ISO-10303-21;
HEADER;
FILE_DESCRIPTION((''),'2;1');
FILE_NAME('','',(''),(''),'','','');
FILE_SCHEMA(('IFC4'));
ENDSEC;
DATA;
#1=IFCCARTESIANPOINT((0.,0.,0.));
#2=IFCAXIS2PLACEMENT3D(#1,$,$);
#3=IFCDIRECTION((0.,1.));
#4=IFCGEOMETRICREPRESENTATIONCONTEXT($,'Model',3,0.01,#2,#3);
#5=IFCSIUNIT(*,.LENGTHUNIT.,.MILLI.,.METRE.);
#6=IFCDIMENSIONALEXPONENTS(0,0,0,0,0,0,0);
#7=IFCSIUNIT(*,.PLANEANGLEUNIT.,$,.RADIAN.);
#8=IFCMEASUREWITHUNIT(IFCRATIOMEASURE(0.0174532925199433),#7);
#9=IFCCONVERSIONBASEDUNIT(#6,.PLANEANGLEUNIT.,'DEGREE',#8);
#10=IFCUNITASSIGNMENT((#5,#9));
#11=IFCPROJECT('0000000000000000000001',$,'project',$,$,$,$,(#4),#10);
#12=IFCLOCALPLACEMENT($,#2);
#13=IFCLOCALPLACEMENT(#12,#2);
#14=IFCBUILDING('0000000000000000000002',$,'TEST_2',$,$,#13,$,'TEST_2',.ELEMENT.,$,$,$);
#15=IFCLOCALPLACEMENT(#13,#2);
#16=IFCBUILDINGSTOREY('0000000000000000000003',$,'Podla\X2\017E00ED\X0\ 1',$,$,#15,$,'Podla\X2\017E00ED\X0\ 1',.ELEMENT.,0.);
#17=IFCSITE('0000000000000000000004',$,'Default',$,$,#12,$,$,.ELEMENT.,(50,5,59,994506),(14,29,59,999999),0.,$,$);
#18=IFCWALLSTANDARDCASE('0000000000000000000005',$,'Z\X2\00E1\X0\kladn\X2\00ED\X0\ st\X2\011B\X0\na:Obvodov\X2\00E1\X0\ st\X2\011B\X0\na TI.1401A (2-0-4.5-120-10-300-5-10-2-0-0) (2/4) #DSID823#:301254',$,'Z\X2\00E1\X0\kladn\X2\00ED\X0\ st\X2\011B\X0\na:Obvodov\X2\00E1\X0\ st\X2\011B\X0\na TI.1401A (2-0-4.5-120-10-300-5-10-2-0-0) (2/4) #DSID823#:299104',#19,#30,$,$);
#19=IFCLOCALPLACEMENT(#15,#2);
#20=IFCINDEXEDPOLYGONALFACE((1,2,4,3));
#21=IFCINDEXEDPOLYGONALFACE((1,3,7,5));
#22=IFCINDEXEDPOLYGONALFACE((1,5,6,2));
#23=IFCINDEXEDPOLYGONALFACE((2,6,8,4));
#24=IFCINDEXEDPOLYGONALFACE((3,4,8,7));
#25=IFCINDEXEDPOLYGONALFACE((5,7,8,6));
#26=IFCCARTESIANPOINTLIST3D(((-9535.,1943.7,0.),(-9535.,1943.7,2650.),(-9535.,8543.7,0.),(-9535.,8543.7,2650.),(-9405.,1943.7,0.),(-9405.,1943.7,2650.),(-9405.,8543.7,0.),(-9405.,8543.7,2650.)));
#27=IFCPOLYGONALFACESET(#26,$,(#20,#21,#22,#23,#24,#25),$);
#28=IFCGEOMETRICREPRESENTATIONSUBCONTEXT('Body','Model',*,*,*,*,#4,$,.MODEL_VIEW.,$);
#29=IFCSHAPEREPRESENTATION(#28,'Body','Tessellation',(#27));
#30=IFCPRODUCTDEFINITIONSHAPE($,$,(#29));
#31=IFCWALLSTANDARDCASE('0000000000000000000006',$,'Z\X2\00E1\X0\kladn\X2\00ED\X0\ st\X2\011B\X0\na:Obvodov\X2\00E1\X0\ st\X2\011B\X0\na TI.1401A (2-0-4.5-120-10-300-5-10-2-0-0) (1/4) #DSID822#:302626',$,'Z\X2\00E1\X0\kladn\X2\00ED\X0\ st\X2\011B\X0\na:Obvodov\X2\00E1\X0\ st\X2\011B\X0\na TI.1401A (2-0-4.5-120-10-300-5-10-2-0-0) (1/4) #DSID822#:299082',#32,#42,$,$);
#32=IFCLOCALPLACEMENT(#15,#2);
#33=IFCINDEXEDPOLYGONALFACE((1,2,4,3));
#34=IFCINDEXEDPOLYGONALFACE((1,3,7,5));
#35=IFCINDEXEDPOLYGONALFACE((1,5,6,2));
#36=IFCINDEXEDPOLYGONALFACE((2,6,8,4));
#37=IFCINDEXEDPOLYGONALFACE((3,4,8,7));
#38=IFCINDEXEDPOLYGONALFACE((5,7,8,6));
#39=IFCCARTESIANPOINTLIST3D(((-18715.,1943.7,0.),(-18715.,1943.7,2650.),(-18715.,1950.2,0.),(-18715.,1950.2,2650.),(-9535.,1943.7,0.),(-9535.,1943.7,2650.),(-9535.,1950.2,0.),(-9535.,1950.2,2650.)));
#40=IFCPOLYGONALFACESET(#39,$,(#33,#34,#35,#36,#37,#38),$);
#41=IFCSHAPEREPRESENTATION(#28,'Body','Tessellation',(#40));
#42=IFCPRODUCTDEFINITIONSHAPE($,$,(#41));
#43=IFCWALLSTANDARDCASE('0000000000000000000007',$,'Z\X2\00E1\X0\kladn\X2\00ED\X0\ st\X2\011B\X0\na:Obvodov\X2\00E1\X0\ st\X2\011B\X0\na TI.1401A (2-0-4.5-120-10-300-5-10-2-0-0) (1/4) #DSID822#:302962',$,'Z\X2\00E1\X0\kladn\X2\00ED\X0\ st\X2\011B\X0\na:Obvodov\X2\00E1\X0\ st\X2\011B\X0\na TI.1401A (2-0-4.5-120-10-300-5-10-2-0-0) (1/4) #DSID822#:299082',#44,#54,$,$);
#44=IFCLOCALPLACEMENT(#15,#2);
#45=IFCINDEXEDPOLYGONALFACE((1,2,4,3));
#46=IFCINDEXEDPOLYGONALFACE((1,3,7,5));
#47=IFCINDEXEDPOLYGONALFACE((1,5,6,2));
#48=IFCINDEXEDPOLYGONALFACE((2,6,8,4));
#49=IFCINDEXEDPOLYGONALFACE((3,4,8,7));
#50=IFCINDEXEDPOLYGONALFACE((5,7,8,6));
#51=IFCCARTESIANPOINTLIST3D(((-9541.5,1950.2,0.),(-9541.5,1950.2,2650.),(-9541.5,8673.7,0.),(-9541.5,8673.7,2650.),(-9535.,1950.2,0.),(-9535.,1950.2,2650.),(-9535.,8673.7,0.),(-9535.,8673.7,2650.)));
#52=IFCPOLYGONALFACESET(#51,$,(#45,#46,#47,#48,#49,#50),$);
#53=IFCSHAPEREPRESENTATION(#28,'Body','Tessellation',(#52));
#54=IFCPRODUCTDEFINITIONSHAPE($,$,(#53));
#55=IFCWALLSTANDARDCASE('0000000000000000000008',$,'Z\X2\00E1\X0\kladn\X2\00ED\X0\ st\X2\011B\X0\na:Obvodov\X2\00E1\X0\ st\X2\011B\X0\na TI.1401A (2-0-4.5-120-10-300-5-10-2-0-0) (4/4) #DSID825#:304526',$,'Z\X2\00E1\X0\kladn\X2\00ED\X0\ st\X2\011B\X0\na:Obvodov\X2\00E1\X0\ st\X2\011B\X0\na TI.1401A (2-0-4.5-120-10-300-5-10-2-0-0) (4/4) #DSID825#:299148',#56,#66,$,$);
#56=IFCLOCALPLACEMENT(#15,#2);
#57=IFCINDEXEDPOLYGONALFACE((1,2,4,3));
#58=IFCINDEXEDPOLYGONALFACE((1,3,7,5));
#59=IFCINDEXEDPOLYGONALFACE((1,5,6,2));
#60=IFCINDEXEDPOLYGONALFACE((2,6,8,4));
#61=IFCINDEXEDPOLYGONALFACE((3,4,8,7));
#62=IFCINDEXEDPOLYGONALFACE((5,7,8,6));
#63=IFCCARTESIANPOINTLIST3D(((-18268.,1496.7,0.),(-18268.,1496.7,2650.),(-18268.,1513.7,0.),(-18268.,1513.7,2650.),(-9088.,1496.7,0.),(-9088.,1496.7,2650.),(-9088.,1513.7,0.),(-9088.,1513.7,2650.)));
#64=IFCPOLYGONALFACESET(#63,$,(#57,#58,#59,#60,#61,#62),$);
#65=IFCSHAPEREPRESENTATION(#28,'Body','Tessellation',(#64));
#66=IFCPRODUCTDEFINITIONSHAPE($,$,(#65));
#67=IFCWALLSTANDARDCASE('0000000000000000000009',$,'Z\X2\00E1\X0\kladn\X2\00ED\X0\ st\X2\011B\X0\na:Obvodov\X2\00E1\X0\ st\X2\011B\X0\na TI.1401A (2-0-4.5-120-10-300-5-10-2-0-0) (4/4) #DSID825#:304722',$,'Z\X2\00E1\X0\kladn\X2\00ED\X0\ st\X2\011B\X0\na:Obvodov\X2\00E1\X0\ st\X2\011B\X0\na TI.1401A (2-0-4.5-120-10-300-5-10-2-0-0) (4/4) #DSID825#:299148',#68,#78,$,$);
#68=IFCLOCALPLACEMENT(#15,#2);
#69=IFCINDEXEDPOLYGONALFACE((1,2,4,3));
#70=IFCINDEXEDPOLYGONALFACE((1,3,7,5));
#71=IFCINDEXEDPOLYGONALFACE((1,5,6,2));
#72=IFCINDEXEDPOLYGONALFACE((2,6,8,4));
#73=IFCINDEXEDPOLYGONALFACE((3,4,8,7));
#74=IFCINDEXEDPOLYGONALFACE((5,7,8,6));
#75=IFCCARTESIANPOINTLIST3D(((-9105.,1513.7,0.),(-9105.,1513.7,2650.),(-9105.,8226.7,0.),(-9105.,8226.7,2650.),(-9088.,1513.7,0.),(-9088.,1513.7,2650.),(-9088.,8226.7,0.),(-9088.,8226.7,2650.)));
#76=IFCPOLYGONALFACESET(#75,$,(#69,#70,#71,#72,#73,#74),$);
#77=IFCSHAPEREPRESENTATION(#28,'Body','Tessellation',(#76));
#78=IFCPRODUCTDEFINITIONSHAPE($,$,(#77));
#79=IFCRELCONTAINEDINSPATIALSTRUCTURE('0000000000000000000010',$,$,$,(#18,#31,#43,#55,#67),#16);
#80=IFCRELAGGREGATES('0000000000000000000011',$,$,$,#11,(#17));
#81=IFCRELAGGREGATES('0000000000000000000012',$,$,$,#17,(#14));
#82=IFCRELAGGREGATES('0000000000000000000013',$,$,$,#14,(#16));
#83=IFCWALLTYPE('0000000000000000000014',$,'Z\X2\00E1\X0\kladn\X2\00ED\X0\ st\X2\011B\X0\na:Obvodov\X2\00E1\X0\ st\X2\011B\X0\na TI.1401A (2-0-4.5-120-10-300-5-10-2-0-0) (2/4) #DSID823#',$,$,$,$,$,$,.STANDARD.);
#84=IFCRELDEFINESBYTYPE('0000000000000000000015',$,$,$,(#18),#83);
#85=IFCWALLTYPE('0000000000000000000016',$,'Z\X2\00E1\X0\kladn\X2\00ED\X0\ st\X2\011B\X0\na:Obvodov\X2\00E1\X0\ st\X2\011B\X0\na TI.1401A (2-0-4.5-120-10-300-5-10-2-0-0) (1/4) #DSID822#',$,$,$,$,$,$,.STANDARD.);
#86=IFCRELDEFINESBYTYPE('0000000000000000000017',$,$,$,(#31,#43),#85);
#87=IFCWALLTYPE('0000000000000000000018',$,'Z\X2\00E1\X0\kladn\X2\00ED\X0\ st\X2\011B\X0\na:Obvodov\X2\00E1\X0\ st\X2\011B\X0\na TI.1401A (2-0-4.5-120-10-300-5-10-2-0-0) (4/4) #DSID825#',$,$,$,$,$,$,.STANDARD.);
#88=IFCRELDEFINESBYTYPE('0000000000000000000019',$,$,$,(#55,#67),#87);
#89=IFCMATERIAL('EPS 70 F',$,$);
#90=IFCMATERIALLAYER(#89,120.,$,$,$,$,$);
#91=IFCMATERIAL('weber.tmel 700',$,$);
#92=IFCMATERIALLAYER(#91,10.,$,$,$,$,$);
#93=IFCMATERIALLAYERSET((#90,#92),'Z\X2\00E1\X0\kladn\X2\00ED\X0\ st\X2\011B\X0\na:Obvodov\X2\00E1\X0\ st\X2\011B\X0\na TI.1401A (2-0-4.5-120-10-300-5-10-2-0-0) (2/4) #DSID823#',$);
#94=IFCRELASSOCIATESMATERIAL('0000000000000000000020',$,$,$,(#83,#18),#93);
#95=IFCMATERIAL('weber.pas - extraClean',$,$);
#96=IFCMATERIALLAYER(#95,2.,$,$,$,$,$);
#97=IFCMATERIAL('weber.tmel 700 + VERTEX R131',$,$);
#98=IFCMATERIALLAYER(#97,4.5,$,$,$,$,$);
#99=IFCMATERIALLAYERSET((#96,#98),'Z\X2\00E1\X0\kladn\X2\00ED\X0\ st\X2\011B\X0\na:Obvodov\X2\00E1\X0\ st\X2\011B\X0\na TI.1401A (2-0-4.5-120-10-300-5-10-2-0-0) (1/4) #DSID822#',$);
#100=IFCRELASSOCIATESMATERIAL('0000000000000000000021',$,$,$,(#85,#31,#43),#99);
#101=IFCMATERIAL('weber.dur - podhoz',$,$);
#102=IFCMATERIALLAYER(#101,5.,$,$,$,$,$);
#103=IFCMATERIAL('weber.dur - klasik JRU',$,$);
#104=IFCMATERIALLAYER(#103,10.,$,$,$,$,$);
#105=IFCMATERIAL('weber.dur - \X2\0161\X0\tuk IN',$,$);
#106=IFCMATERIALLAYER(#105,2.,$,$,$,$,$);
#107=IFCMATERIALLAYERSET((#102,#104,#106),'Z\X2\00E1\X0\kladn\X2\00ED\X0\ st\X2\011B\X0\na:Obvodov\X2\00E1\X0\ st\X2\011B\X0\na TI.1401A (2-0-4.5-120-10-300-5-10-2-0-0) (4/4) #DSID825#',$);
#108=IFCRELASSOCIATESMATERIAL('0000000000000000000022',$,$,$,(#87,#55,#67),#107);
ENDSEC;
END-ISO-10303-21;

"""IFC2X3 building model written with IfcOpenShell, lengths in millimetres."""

from ifc_helpers import new_model, entity, si_unit, converted_unit, direction, frame, frame_2d, origin, place, context, subcontext, project, spatial, rectangle, extrude, material, layer, layer_set, layer_usage, type_object, element, save


model = new_model("IFC2X3")

# Units and contexts
model_context = context("Model", 3, precision=0.01, world=origin(), true_north=direction((0.0, 1.0)))
body_context = subcontext(model_context, "Body", "Model", "MODEL_VIEW")
ifc_project = project(units=[si_unit("LENGTHUNIT", "METRE", prefix="MILLI"), converted_unit("PLANEANGLEUNIT", "DEGREE", entity("IfcRatioMeasure", 0.0174532925199433), si_unit("PLANEANGLEUNIT", "RADIAN"), dimensions=[0, 0, 0, 0, 0, 0, 0])], contexts=[model_context])

# Site, building, storey
site_placement = place(None, origin())
site = spatial("IfcSite", under=ifc_project, at=site_placement, Name="Default", CompositionType="ELEMENT", RefLatitude=(50, 5, 59, 994506), RefLongitude=(14, 29, 59, 999999), RefElevation=0.0)
building_placement = place(site_placement, origin())
building = spatial("IfcBuilding", under=site, at=building_placement, Name="TEST_2", LongName="TEST_2", CompositionType="ELEMENT")
storey_placement = place(building_placement, origin())
storey = spatial("IfcBuildingStorey", under=building, at=storey_placement, Name="Podlaží 1", LongName="Podlaží 1", CompositionType="ELEMENT", Elevation=0.0)

# Shared definitions
ifc_material_1 = material(Name="EPS 70 F")
ifc_layer_1 = layer(ifc_material_1, 120.0)
ifc_material_2 = material(Name="weber.tmel 700")
ifc_layer_2 = layer(ifc_material_2, 10.0)
ifc_layer_set_1 = layer_set([ifc_layer_1, ifc_layer_2], Name="Základní stěna:Obvodová stěna TI.1401A (2-0-4.5-120-10-300-5-10-2-0-0) (2/4) #DSID823#")
wall_type_1 = type_object("IfcWallType", Name="Základní stěna:Obvodová stěna TI.1401A (2-0-4.5-120-10-300-5-10-2-0-0) (2/4) #DSID823#", PredefinedType="STANDARD", material=ifc_layer_set_1)

# Wall
ifc_layer_usage_1 = layer_usage(ifc_layer_set_1, "AXIS2", "POSITIVE", -65.0)
wall_1_placement = place(storey_placement, frame((-9470.0, 8543.7, 0.0), z_axis=(0.0, 0.0, 1.0), x_axis=(0.0, -1.0, 0.0)))
element("IfcWallStandardCase", 1, at=wall_1_placement, inside=storey, type_object=wall_type_1, material=ifc_layer_usage_1, Name="Základní stěna:Obvodová stěna TI.1401A (2-0-4.5-120-10-300-5-10-2-0-0) (2/4) #DSID823#:301254", ObjectType="Základní stěna:Obvodová stěna TI.1401A (2-0-4.5-120-10-300-5-10-2-0-0) (2/4) #DSID823#:299104", context=body_context, shape_type="SweptSolid", body=[
    extrude(rectangle(XDim=6600.0, YDim=130.0, at=frame_2d((3300.0, 0.0), x_axis=(-1.0, 0.0))), origin(), (0.0, 0.0, 1.0), 2650.0),
])

# Shared definitions
ifc_material_3 = material(Name="weber.pas - extraClean")
ifc_layer_3 = layer(ifc_material_3, 2.0)
ifc_material_4 = material(Name="weber.tmel 700 + VERTEX R131")
ifc_layer_4 = layer(ifc_material_4, 4.5)
ifc_layer_set_2 = layer_set([ifc_layer_3, ifc_layer_4], Name="Základní stěna:Obvodová stěna TI.1401A (2-0-4.5-120-10-300-5-10-2-0-0) (1/4) #DSID822#")
wall_type_2 = type_object("IfcWallType", Name="Základní stěna:Obvodová stěna TI.1401A (2-0-4.5-120-10-300-5-10-2-0-0) (1/4) #DSID822#", PredefinedType="STANDARD", material=ifc_layer_set_2)

# Walls
ifc_layer_usage_2 = layer_usage(ifc_layer_set_2, "AXIS2", "NEGATIVE", 3.2)
wall_2_placement = place(storey_placement, frame((-18715.0, 1947.0, 0.0)))
element("IfcWallStandardCase", 2, at=wall_2_placement, inside=storey, type_object=wall_type_2, material=ifc_layer_usage_2, Name="Základní stěna:Obvodová stěna TI.1401A (2-0-4.5-120-10-300-5-10-2-0-0) (1/4) #DSID822#:302626", ObjectType="Základní stěna:Obvodová stěna TI.1401A (2-0-4.5-120-10-300-5-10-2-0-0) (1/4) #DSID822#:299082", context=body_context, shape_type="SweptSolid", body=[
    extrude(rectangle(XDim=9180.0, YDim=6.5, at=frame_2d((4590.0, 0.0), x_axis=(-1.0, 0.0))), origin(), (0.0, 0.0, 1.0), 2650.0),
])
ifc_layer_usage_3 = layer_usage(ifc_layer_set_2, "AXIS2", "POSITIVE", -3.2)
wall_3_placement = place(storey_placement, frame((-9538.2, 8673.7, 0.0), z_axis=(0.0, 0.0, 1.0), x_axis=(0.0, -1.0, 0.0)))
element("IfcWallStandardCase", 3, at=wall_3_placement, inside=storey, type_object=wall_type_2, material=ifc_layer_usage_3, Name="Základní stěna:Obvodová stěna TI.1401A (2-0-4.5-120-10-300-5-10-2-0-0) (1/4) #DSID822#:302962", ObjectType="Základní stěna:Obvodová stěna TI.1401A (2-0-4.5-120-10-300-5-10-2-0-0) (1/4) #DSID822#:299082", context=body_context, shape_type="SweptSolid", body=[
    extrude(rectangle(XDim=6723.5, YDim=6.5, at=frame_2d((3361.8, 0.0), x_axis=(-1.0, 0.0))), origin(), (0.0, 0.0, 1.0), 2650.0),
])

# Shared definitions
ifc_material_5 = material(Name="weber.dur - podhoz")
ifc_layer_5 = layer(ifc_material_5, 5.0)
ifc_material_6 = material(Name="weber.dur - klasik JRU")
ifc_layer_6 = layer(ifc_material_6, 10.0)
ifc_material_7 = material(Name="weber.dur - štuk IN")
ifc_layer_7 = layer(ifc_material_7, 2.0)
ifc_layer_set_3 = layer_set([ifc_layer_5, ifc_layer_6, ifc_layer_7], Name="Základní stěna:Obvodová stěna TI.1401A (2-0-4.5-120-10-300-5-10-2-0-0) (4/4) #DSID825#")
wall_type_3 = type_object("IfcWallType", Name="Základní stěna:Obvodová stěna TI.1401A (2-0-4.5-120-10-300-5-10-2-0-0) (4/4) #DSID825#", PredefinedType="STANDARD", material=ifc_layer_set_3)

# Walls
ifc_layer_usage_4 = layer_usage(ifc_layer_set_3, "AXIS2", "POSITIVE", -8.5)
wall_4_placement = place(storey_placement, frame((-18268.0, 1505.2, 0.0)))
element("IfcWallStandardCase", 4, at=wall_4_placement, inside=storey, type_object=wall_type_3, material=ifc_layer_usage_4, Name="Základní stěna:Obvodová stěna TI.1401A (2-0-4.5-120-10-300-5-10-2-0-0) (4/4) #DSID825#:304526", ObjectType="Základní stěna:Obvodová stěna TI.1401A (2-0-4.5-120-10-300-5-10-2-0-0) (4/4) #DSID825#:299148", context=body_context, shape_type="SweptSolid", body=[
    extrude(rectangle(XDim=9180.0, YDim=17.0, at=frame_2d((4590.0, 0.0), x_axis=(-1.0, 0.0))), origin(), (0.0, 0.0, 1.0), 2650.0),
])
ifc_layer_usage_5 = layer_usage(ifc_layer_set_3, "AXIS2", "POSITIVE", -8.5)
wall_5_placement = place(storey_placement, frame((-9096.5, 1513.7, 0.0), z_axis=(0.0, 0.0, 1.0), x_axis=(0.0, 1.0, 0.0)))
element("IfcWallStandardCase", 5, at=wall_5_placement, inside=storey, type_object=wall_type_3, material=ifc_layer_usage_5, Name="Základní stěna:Obvodová stěna TI.1401A (2-0-4.5-120-10-300-5-10-2-0-0) (4/4) #DSID825#:304722", ObjectType="Základní stěna:Obvodová stěna TI.1401A (2-0-4.5-120-10-300-5-10-2-0-0) (4/4) #DSID825#:299148", context=body_context, shape_type="SweptSolid", body=[
    extrude(rectangle(XDim=6713.0, YDim=17.0, at=frame_2d((3356.5, 0.0), x_axis=(-1.0, 0.0))), origin(), (0.0, 0.0, 1.0), 2650.0),
])

save(model, "model.ifc")
